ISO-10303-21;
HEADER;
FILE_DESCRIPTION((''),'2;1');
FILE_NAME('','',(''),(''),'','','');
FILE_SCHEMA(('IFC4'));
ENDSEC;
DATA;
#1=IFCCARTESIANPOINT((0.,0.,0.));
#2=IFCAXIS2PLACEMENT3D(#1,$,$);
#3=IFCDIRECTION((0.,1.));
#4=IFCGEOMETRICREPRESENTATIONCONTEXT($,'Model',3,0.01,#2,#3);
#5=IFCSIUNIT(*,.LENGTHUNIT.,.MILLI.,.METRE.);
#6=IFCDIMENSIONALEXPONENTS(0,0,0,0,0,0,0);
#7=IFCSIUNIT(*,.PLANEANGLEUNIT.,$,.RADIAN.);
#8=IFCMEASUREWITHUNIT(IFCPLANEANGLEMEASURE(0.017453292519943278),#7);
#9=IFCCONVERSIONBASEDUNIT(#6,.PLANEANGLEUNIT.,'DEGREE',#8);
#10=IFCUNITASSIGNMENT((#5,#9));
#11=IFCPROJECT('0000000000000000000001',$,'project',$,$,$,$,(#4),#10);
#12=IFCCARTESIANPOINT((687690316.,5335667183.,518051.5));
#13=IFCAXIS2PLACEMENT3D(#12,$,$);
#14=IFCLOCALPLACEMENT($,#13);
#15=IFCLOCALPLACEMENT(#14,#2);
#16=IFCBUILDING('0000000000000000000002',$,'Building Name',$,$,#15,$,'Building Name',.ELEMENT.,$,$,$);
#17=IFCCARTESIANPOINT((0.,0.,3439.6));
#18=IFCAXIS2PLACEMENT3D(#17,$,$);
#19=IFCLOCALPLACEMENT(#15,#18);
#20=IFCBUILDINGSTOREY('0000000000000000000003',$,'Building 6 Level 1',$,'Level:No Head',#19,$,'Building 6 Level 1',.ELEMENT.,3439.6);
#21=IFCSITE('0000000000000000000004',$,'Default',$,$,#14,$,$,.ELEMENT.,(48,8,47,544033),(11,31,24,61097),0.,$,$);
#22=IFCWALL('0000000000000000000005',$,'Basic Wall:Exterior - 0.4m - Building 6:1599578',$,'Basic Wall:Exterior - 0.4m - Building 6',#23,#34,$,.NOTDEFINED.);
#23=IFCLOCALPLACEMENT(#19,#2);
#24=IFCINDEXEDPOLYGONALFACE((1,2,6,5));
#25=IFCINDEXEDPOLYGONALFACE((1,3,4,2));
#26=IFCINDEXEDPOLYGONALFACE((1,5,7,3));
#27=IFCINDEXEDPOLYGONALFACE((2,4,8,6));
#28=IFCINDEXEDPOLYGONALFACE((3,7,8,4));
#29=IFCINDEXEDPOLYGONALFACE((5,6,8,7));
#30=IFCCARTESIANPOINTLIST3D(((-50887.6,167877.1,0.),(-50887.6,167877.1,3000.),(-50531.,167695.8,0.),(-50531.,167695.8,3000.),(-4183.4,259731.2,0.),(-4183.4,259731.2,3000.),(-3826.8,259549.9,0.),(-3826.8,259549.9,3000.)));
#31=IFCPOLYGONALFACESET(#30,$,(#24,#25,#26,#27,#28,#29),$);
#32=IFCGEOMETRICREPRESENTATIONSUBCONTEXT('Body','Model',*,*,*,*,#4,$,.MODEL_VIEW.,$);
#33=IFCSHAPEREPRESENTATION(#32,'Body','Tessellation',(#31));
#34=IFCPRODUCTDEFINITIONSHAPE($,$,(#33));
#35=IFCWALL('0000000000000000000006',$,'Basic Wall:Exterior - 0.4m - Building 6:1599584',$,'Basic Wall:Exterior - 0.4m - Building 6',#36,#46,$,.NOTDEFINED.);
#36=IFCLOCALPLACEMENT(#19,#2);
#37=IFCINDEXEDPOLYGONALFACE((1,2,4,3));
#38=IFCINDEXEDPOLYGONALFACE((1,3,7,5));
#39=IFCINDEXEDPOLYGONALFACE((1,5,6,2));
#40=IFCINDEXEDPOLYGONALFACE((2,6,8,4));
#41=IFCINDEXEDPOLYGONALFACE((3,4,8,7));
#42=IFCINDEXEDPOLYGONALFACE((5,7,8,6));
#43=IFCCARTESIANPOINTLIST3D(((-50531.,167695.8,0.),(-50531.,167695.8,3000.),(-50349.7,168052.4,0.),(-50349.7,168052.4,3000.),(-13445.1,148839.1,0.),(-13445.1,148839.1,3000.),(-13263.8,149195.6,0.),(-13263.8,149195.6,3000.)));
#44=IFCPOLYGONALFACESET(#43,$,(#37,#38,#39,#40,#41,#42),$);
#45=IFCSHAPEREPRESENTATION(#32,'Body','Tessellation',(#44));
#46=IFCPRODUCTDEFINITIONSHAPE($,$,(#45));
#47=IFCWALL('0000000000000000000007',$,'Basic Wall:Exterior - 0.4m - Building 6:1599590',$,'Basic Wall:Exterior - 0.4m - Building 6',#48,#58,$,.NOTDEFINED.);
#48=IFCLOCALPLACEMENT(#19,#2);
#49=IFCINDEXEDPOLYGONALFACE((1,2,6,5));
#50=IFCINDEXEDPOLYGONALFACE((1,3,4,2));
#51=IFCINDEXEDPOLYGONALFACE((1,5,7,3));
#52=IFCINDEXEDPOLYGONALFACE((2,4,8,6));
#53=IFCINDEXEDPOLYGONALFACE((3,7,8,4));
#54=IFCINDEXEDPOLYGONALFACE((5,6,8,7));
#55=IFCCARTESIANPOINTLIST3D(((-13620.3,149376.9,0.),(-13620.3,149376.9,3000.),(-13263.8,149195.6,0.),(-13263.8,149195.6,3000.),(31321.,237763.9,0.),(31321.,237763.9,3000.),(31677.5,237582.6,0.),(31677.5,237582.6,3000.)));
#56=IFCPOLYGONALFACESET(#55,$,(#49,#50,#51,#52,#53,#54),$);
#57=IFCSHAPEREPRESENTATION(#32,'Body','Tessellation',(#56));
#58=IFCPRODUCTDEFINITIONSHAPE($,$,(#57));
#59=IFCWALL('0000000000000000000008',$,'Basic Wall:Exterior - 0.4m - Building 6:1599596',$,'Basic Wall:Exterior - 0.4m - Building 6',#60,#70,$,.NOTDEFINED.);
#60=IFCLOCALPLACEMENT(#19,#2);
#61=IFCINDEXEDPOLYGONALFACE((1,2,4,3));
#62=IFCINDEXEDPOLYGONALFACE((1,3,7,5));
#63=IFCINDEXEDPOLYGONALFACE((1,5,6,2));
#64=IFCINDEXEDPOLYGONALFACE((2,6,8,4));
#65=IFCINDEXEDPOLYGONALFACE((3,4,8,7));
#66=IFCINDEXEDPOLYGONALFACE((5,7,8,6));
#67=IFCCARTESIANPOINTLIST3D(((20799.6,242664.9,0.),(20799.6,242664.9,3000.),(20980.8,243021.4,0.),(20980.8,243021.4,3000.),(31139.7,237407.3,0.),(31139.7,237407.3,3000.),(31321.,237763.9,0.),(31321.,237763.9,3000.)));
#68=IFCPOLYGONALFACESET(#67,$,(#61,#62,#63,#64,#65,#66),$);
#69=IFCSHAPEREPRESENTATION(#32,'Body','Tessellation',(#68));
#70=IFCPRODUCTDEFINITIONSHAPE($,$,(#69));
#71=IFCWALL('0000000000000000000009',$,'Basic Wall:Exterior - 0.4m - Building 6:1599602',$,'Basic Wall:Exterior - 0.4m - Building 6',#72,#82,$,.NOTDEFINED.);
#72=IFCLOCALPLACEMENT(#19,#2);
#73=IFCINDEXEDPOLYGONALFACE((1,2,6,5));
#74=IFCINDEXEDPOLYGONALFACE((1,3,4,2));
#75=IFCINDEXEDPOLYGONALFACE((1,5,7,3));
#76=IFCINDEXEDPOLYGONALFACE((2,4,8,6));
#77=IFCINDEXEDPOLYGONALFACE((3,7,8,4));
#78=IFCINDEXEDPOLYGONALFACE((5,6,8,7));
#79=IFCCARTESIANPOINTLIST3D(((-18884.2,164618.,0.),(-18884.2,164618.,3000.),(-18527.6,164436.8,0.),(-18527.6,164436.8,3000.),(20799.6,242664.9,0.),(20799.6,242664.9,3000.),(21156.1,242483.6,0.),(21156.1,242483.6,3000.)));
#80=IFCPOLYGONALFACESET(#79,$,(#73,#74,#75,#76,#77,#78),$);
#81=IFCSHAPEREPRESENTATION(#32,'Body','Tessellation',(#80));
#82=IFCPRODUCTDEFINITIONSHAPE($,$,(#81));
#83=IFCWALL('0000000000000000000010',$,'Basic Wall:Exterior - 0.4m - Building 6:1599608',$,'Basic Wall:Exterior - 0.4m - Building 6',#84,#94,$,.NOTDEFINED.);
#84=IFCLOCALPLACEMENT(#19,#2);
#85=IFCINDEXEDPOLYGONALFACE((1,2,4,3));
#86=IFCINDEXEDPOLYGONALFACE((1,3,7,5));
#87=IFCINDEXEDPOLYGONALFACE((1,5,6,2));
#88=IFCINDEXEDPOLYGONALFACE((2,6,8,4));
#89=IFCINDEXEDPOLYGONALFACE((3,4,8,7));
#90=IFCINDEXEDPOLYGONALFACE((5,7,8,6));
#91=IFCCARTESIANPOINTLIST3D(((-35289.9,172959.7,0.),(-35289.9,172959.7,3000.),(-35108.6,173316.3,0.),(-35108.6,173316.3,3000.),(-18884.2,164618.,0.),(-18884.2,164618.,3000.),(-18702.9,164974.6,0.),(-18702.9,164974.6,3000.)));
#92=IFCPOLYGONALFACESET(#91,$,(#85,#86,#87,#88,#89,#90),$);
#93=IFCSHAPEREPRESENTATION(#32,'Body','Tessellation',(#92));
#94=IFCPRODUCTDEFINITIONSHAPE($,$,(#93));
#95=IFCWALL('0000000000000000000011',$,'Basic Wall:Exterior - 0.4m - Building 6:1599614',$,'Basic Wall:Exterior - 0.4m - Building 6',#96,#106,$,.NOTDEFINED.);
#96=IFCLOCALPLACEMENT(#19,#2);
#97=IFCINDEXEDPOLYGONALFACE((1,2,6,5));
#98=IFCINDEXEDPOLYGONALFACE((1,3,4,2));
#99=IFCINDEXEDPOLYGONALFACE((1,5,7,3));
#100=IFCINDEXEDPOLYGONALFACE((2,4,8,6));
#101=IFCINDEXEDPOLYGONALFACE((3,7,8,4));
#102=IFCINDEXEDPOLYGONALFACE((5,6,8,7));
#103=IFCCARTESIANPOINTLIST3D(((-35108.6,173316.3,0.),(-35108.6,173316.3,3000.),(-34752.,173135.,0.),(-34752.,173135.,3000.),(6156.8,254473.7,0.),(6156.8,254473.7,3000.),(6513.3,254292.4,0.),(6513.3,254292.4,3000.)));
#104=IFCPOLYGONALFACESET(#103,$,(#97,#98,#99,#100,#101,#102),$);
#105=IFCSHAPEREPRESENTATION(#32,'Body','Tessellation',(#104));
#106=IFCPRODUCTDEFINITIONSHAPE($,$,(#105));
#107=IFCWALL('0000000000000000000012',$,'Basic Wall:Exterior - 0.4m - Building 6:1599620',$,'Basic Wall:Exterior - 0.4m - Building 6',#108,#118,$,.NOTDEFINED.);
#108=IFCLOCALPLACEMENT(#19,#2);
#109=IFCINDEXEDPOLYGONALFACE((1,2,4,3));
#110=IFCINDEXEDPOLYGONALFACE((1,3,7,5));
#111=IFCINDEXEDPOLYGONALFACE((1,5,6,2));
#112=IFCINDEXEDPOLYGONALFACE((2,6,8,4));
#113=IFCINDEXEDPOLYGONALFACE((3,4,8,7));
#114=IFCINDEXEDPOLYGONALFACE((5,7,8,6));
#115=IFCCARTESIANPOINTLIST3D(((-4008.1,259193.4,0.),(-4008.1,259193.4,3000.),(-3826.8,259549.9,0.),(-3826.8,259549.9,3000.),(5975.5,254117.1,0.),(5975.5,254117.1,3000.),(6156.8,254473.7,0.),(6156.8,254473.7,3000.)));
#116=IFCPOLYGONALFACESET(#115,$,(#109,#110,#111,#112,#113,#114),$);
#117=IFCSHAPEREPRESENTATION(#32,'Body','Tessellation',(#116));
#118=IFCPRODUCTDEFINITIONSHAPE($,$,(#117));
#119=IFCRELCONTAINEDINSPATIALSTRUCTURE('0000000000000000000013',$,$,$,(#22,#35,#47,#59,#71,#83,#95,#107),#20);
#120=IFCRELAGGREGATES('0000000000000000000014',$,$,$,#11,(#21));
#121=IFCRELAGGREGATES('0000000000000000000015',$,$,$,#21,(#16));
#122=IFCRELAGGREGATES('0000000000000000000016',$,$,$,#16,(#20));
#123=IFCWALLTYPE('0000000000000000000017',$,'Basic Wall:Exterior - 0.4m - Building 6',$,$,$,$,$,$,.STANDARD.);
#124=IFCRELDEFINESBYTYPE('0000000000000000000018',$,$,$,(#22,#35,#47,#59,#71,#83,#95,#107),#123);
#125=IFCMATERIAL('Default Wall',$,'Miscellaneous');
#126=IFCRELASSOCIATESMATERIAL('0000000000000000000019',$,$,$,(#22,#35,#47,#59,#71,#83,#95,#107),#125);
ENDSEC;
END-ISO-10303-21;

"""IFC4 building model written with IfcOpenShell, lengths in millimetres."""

from ifc_helpers import new_model, entity, si_unit, converted_unit, direction, frame, origin, place, context, subcontext, project, spatial, indexed_curve, outline, extrude, material, type_object, element, save


model = new_model("IFC4")

# Units and contexts
model_context = context("Model", 3, precision=0.01, world=origin(), true_north=direction((0.0, 1.0)))
body_context = subcontext(model_context, "Body", "Model", "MODEL_VIEW")
ifc_project = project(units=[si_unit("LENGTHUNIT", "METRE", prefix="MILLI"), converted_unit("PLANEANGLEUNIT", "DEGREE", entity("IfcPlaneAngleMeasure", 0.017453292519943278), si_unit("PLANEANGLEUNIT", "RADIAN"), dimensions=[0, 0, 0, 0, 0, 0, 0])], contexts=[model_context])

# Site, building, storey
site_placement = place(None, frame((687690316.0, 5335667183.0, 518051.5)))
site = spatial("IfcSite", under=ifc_project, at=site_placement, Name="Default", CompositionType="ELEMENT", RefLatitude=(48, 8, 47, 544033), RefLongitude=(11, 31, 24, 61097), RefElevation=0.0)
building_placement = place(site_placement, origin())
building = spatial("IfcBuilding", under=site, at=building_placement, Name="Building Name", LongName="Building Name", CompositionType="ELEMENT")
storey_placement = place(building_placement, frame((0.0, 0.0, 3439.6)))
storey = spatial("IfcBuildingStorey", under=building, at=storey_placement, Name="Building 6 Level 1", ObjectType="Level:No Head", LongName="Building 6 Level 1", CompositionType="ELEMENT", Elevation=3439.6)

# Walls
ifc_material_1 = material(Name="Default Wall", Category="Miscellaneous")
wall_type = type_object("IfcWallType", Name="Basic Wall:Exterior - 0.4m - Building 6", PredefinedType="STANDARD")
wall_1_placement = place(storey_placement, frame((-4005.1, 259640.6, 0.0), z_axis=(0.0, 0.0, 1.0), x_axis=(-0.453237, -0.89139, 0.0)))
element("IfcWall", 1, at=wall_1_placement, inside=storey, type_object=wall_type, material=ifc_material_1, Name="Basic Wall:Exterior - 0.4m - Building 6:1599578", ObjectType="Basic Wall:Exterior - 0.4m - Building 6", PredefinedType="NOTDEFINED", context=body_context, shape_type="SweptSolid", body=[
    extrude(outline(indexed_curve([(103045.9, 200.0), (0.0, 200.0), (0.0, -200.0), (103045.9, -200.0), (103045.9, 200.0)], self_intersect=False)), origin(), (0.0, 0.0, 1.0), 3000.0),
])
wall_2_placement = place(storey_placement, frame((-50440.4, 167874.1, 0.0), z_axis=(0.0, 0.0, 1.0), x_axis=(0.89139, -0.453237, 0.0)))
element("IfcWall", 2, at=wall_2_placement, inside=storey, type_object=wall_type, material=ifc_material_1, Name="Basic Wall:Exterior - 0.4m - Building 6:1599584", ObjectType="Basic Wall:Exterior - 0.4m - Building 6", PredefinedType="NOTDEFINED", context=body_context, shape_type="SweptSolid", body=[
    extrude(outline(indexed_curve([(41604.6, 200.0), (0.0, 200.0), (0.0, -200.0), (41604.6, -200.0), (41604.6, 200.0)], self_intersect=False)), origin(), (0.0, 0.0, 1.0), 3000.0),
])
wall_3_placement = place(storey_placement, frame((-13442.0, 149286.3, 0.0), z_axis=(0.0, 0.0, 1.0), x_axis=(0.453237, 0.89139, 0.0)))
element("IfcWall", 3, at=wall_3_placement, inside=storey, type_object=wall_type, material=ifc_material_1, Name="Basic Wall:Exterior - 0.4m - Building 6:1599590", ObjectType="Basic Wall:Exterior - 0.4m - Building 6", PredefinedType="NOTDEFINED", context=body_context, shape_type="SweptSolid", body=[
    extrude(outline(indexed_curve([(99156.3, 200.0), (0.0, 200.0), (0.0, -200.0), (99156.3, -200.0), (99156.3, 200.0)], self_intersect=False)), origin(), (0.0, 0.0, 1.0), 3000.0),
])
wall_4_placement = place(storey_placement, frame((31230.3, 237585.6, 0.0), z_axis=(0.0, 0.0, 1.0), x_axis=(-0.89139, 0.453237, 0.0)))
element("IfcWall", 4, at=wall_4_placement, inside=storey, type_object=wall_type, material=ifc_material_1, Name="Basic Wall:Exterior - 0.4m - Building 6:1599596", ObjectType="Basic Wall:Exterior - 0.4m - Building 6", PredefinedType="NOTDEFINED", context=body_context, shape_type="SweptSolid", body=[
    extrude(outline(indexed_curve([(11600.0, 200.0), (0.0, 200.0), (0.0, -200.0), (11600.0, -200.0), (11600.0, 200.0)], self_intersect=False)), origin(), (0.0, 0.0, 1.0), 3000.0),
])
wall_5_placement = place(storey_placement, frame((20977.8, 242574.2, 0.0), z_axis=(0.0, 0.0, 1.0), x_axis=(-0.453237, -0.89139, 0.0)))
element("IfcWall", 5, at=wall_5_placement, inside=storey, type_object=wall_type, material=ifc_material_1, Name="Basic Wall:Exterior - 0.4m - Building 6:1599602", ObjectType="Basic Wall:Exterior - 0.4m - Building 6", PredefinedType="NOTDEFINED", context=body_context, shape_type="SweptSolid", body=[
    extrude(outline(indexed_curve([(87556.3, 200.0), (0.0, 200.0), (0.0, -200.0), (87556.3, -200.0), (87556.3, 200.0)], self_intersect=False)), origin(), (0.0, 0.0, 1.0), 3000.0),
])
wall_6_placement = place(storey_placement, frame((-18793.5, 164796.3, 0.0), z_axis=(0.0, 0.0, 1.0), x_axis=(-0.89139, 0.453237, 0.0)))
element("IfcWall", 6, at=wall_6_placement, inside=storey, type_object=wall_type, material=ifc_material_1, Name="Basic Wall:Exterior - 0.4m - Building 6:1599608", ObjectType="Basic Wall:Exterior - 0.4m - Building 6", PredefinedType="NOTDEFINED", context=body_context, shape_type="SweptSolid", body=[
    extrude(outline(indexed_curve([(18404.6, 200.0), (0.0, 200.0), (0.0, -200.0), (18404.6, -200.0), (18404.6, 200.0)], self_intersect=False)), origin(), (0.0, 0.0, 1.0), 3000.0),
])
wall_7_placement = place(storey_placement, frame((-34930.3, 173225.6, 0.0), z_axis=(0.0, 0.0, 1.0), x_axis=(0.453237, 0.89139, 0.0)))
element("IfcWall", 7, at=wall_7_placement, inside=storey, type_object=wall_type, material=ifc_material_1, Name="Basic Wall:Exterior - 0.4m - Building 6:1599614", ObjectType="Basic Wall:Exterior - 0.4m - Building 6", PredefinedType="NOTDEFINED", context=body_context, shape_type="SweptSolid", body=[
    extrude(outline(indexed_curve([(91045.9, 200.0), (0.0, 200.0), (0.0, -200.0), (91045.9, -200.0), (91045.9, 200.0)], self_intersect=False)), origin(), (0.0, 0.0, 1.0), 3000.0),
])
wall_8_placement = place(storey_placement, frame((6066.1, 254295.4, 0.0), z_axis=(0.0, 0.0, 1.0), x_axis=(-0.89139, 0.453237, 0.0)))
element("IfcWall", 8, at=wall_8_placement, inside=storey, type_object=wall_type, material=ifc_material_1, Name="Basic Wall:Exterior - 0.4m - Building 6:1599620", ObjectType="Basic Wall:Exterior - 0.4m - Building 6", PredefinedType="NOTDEFINED", context=body_context, shape_type="SweptSolid", body=[
    extrude(outline(indexed_curve([(11200.0, 200.0), (0.0, 200.0), (0.0, -200.0), (11200.0, -200.0), (11200.0, 200.0)], self_intersect=False)), origin(), (0.0, 0.0, 1.0), 3000.0),
])

save(model, "model.ifc")
